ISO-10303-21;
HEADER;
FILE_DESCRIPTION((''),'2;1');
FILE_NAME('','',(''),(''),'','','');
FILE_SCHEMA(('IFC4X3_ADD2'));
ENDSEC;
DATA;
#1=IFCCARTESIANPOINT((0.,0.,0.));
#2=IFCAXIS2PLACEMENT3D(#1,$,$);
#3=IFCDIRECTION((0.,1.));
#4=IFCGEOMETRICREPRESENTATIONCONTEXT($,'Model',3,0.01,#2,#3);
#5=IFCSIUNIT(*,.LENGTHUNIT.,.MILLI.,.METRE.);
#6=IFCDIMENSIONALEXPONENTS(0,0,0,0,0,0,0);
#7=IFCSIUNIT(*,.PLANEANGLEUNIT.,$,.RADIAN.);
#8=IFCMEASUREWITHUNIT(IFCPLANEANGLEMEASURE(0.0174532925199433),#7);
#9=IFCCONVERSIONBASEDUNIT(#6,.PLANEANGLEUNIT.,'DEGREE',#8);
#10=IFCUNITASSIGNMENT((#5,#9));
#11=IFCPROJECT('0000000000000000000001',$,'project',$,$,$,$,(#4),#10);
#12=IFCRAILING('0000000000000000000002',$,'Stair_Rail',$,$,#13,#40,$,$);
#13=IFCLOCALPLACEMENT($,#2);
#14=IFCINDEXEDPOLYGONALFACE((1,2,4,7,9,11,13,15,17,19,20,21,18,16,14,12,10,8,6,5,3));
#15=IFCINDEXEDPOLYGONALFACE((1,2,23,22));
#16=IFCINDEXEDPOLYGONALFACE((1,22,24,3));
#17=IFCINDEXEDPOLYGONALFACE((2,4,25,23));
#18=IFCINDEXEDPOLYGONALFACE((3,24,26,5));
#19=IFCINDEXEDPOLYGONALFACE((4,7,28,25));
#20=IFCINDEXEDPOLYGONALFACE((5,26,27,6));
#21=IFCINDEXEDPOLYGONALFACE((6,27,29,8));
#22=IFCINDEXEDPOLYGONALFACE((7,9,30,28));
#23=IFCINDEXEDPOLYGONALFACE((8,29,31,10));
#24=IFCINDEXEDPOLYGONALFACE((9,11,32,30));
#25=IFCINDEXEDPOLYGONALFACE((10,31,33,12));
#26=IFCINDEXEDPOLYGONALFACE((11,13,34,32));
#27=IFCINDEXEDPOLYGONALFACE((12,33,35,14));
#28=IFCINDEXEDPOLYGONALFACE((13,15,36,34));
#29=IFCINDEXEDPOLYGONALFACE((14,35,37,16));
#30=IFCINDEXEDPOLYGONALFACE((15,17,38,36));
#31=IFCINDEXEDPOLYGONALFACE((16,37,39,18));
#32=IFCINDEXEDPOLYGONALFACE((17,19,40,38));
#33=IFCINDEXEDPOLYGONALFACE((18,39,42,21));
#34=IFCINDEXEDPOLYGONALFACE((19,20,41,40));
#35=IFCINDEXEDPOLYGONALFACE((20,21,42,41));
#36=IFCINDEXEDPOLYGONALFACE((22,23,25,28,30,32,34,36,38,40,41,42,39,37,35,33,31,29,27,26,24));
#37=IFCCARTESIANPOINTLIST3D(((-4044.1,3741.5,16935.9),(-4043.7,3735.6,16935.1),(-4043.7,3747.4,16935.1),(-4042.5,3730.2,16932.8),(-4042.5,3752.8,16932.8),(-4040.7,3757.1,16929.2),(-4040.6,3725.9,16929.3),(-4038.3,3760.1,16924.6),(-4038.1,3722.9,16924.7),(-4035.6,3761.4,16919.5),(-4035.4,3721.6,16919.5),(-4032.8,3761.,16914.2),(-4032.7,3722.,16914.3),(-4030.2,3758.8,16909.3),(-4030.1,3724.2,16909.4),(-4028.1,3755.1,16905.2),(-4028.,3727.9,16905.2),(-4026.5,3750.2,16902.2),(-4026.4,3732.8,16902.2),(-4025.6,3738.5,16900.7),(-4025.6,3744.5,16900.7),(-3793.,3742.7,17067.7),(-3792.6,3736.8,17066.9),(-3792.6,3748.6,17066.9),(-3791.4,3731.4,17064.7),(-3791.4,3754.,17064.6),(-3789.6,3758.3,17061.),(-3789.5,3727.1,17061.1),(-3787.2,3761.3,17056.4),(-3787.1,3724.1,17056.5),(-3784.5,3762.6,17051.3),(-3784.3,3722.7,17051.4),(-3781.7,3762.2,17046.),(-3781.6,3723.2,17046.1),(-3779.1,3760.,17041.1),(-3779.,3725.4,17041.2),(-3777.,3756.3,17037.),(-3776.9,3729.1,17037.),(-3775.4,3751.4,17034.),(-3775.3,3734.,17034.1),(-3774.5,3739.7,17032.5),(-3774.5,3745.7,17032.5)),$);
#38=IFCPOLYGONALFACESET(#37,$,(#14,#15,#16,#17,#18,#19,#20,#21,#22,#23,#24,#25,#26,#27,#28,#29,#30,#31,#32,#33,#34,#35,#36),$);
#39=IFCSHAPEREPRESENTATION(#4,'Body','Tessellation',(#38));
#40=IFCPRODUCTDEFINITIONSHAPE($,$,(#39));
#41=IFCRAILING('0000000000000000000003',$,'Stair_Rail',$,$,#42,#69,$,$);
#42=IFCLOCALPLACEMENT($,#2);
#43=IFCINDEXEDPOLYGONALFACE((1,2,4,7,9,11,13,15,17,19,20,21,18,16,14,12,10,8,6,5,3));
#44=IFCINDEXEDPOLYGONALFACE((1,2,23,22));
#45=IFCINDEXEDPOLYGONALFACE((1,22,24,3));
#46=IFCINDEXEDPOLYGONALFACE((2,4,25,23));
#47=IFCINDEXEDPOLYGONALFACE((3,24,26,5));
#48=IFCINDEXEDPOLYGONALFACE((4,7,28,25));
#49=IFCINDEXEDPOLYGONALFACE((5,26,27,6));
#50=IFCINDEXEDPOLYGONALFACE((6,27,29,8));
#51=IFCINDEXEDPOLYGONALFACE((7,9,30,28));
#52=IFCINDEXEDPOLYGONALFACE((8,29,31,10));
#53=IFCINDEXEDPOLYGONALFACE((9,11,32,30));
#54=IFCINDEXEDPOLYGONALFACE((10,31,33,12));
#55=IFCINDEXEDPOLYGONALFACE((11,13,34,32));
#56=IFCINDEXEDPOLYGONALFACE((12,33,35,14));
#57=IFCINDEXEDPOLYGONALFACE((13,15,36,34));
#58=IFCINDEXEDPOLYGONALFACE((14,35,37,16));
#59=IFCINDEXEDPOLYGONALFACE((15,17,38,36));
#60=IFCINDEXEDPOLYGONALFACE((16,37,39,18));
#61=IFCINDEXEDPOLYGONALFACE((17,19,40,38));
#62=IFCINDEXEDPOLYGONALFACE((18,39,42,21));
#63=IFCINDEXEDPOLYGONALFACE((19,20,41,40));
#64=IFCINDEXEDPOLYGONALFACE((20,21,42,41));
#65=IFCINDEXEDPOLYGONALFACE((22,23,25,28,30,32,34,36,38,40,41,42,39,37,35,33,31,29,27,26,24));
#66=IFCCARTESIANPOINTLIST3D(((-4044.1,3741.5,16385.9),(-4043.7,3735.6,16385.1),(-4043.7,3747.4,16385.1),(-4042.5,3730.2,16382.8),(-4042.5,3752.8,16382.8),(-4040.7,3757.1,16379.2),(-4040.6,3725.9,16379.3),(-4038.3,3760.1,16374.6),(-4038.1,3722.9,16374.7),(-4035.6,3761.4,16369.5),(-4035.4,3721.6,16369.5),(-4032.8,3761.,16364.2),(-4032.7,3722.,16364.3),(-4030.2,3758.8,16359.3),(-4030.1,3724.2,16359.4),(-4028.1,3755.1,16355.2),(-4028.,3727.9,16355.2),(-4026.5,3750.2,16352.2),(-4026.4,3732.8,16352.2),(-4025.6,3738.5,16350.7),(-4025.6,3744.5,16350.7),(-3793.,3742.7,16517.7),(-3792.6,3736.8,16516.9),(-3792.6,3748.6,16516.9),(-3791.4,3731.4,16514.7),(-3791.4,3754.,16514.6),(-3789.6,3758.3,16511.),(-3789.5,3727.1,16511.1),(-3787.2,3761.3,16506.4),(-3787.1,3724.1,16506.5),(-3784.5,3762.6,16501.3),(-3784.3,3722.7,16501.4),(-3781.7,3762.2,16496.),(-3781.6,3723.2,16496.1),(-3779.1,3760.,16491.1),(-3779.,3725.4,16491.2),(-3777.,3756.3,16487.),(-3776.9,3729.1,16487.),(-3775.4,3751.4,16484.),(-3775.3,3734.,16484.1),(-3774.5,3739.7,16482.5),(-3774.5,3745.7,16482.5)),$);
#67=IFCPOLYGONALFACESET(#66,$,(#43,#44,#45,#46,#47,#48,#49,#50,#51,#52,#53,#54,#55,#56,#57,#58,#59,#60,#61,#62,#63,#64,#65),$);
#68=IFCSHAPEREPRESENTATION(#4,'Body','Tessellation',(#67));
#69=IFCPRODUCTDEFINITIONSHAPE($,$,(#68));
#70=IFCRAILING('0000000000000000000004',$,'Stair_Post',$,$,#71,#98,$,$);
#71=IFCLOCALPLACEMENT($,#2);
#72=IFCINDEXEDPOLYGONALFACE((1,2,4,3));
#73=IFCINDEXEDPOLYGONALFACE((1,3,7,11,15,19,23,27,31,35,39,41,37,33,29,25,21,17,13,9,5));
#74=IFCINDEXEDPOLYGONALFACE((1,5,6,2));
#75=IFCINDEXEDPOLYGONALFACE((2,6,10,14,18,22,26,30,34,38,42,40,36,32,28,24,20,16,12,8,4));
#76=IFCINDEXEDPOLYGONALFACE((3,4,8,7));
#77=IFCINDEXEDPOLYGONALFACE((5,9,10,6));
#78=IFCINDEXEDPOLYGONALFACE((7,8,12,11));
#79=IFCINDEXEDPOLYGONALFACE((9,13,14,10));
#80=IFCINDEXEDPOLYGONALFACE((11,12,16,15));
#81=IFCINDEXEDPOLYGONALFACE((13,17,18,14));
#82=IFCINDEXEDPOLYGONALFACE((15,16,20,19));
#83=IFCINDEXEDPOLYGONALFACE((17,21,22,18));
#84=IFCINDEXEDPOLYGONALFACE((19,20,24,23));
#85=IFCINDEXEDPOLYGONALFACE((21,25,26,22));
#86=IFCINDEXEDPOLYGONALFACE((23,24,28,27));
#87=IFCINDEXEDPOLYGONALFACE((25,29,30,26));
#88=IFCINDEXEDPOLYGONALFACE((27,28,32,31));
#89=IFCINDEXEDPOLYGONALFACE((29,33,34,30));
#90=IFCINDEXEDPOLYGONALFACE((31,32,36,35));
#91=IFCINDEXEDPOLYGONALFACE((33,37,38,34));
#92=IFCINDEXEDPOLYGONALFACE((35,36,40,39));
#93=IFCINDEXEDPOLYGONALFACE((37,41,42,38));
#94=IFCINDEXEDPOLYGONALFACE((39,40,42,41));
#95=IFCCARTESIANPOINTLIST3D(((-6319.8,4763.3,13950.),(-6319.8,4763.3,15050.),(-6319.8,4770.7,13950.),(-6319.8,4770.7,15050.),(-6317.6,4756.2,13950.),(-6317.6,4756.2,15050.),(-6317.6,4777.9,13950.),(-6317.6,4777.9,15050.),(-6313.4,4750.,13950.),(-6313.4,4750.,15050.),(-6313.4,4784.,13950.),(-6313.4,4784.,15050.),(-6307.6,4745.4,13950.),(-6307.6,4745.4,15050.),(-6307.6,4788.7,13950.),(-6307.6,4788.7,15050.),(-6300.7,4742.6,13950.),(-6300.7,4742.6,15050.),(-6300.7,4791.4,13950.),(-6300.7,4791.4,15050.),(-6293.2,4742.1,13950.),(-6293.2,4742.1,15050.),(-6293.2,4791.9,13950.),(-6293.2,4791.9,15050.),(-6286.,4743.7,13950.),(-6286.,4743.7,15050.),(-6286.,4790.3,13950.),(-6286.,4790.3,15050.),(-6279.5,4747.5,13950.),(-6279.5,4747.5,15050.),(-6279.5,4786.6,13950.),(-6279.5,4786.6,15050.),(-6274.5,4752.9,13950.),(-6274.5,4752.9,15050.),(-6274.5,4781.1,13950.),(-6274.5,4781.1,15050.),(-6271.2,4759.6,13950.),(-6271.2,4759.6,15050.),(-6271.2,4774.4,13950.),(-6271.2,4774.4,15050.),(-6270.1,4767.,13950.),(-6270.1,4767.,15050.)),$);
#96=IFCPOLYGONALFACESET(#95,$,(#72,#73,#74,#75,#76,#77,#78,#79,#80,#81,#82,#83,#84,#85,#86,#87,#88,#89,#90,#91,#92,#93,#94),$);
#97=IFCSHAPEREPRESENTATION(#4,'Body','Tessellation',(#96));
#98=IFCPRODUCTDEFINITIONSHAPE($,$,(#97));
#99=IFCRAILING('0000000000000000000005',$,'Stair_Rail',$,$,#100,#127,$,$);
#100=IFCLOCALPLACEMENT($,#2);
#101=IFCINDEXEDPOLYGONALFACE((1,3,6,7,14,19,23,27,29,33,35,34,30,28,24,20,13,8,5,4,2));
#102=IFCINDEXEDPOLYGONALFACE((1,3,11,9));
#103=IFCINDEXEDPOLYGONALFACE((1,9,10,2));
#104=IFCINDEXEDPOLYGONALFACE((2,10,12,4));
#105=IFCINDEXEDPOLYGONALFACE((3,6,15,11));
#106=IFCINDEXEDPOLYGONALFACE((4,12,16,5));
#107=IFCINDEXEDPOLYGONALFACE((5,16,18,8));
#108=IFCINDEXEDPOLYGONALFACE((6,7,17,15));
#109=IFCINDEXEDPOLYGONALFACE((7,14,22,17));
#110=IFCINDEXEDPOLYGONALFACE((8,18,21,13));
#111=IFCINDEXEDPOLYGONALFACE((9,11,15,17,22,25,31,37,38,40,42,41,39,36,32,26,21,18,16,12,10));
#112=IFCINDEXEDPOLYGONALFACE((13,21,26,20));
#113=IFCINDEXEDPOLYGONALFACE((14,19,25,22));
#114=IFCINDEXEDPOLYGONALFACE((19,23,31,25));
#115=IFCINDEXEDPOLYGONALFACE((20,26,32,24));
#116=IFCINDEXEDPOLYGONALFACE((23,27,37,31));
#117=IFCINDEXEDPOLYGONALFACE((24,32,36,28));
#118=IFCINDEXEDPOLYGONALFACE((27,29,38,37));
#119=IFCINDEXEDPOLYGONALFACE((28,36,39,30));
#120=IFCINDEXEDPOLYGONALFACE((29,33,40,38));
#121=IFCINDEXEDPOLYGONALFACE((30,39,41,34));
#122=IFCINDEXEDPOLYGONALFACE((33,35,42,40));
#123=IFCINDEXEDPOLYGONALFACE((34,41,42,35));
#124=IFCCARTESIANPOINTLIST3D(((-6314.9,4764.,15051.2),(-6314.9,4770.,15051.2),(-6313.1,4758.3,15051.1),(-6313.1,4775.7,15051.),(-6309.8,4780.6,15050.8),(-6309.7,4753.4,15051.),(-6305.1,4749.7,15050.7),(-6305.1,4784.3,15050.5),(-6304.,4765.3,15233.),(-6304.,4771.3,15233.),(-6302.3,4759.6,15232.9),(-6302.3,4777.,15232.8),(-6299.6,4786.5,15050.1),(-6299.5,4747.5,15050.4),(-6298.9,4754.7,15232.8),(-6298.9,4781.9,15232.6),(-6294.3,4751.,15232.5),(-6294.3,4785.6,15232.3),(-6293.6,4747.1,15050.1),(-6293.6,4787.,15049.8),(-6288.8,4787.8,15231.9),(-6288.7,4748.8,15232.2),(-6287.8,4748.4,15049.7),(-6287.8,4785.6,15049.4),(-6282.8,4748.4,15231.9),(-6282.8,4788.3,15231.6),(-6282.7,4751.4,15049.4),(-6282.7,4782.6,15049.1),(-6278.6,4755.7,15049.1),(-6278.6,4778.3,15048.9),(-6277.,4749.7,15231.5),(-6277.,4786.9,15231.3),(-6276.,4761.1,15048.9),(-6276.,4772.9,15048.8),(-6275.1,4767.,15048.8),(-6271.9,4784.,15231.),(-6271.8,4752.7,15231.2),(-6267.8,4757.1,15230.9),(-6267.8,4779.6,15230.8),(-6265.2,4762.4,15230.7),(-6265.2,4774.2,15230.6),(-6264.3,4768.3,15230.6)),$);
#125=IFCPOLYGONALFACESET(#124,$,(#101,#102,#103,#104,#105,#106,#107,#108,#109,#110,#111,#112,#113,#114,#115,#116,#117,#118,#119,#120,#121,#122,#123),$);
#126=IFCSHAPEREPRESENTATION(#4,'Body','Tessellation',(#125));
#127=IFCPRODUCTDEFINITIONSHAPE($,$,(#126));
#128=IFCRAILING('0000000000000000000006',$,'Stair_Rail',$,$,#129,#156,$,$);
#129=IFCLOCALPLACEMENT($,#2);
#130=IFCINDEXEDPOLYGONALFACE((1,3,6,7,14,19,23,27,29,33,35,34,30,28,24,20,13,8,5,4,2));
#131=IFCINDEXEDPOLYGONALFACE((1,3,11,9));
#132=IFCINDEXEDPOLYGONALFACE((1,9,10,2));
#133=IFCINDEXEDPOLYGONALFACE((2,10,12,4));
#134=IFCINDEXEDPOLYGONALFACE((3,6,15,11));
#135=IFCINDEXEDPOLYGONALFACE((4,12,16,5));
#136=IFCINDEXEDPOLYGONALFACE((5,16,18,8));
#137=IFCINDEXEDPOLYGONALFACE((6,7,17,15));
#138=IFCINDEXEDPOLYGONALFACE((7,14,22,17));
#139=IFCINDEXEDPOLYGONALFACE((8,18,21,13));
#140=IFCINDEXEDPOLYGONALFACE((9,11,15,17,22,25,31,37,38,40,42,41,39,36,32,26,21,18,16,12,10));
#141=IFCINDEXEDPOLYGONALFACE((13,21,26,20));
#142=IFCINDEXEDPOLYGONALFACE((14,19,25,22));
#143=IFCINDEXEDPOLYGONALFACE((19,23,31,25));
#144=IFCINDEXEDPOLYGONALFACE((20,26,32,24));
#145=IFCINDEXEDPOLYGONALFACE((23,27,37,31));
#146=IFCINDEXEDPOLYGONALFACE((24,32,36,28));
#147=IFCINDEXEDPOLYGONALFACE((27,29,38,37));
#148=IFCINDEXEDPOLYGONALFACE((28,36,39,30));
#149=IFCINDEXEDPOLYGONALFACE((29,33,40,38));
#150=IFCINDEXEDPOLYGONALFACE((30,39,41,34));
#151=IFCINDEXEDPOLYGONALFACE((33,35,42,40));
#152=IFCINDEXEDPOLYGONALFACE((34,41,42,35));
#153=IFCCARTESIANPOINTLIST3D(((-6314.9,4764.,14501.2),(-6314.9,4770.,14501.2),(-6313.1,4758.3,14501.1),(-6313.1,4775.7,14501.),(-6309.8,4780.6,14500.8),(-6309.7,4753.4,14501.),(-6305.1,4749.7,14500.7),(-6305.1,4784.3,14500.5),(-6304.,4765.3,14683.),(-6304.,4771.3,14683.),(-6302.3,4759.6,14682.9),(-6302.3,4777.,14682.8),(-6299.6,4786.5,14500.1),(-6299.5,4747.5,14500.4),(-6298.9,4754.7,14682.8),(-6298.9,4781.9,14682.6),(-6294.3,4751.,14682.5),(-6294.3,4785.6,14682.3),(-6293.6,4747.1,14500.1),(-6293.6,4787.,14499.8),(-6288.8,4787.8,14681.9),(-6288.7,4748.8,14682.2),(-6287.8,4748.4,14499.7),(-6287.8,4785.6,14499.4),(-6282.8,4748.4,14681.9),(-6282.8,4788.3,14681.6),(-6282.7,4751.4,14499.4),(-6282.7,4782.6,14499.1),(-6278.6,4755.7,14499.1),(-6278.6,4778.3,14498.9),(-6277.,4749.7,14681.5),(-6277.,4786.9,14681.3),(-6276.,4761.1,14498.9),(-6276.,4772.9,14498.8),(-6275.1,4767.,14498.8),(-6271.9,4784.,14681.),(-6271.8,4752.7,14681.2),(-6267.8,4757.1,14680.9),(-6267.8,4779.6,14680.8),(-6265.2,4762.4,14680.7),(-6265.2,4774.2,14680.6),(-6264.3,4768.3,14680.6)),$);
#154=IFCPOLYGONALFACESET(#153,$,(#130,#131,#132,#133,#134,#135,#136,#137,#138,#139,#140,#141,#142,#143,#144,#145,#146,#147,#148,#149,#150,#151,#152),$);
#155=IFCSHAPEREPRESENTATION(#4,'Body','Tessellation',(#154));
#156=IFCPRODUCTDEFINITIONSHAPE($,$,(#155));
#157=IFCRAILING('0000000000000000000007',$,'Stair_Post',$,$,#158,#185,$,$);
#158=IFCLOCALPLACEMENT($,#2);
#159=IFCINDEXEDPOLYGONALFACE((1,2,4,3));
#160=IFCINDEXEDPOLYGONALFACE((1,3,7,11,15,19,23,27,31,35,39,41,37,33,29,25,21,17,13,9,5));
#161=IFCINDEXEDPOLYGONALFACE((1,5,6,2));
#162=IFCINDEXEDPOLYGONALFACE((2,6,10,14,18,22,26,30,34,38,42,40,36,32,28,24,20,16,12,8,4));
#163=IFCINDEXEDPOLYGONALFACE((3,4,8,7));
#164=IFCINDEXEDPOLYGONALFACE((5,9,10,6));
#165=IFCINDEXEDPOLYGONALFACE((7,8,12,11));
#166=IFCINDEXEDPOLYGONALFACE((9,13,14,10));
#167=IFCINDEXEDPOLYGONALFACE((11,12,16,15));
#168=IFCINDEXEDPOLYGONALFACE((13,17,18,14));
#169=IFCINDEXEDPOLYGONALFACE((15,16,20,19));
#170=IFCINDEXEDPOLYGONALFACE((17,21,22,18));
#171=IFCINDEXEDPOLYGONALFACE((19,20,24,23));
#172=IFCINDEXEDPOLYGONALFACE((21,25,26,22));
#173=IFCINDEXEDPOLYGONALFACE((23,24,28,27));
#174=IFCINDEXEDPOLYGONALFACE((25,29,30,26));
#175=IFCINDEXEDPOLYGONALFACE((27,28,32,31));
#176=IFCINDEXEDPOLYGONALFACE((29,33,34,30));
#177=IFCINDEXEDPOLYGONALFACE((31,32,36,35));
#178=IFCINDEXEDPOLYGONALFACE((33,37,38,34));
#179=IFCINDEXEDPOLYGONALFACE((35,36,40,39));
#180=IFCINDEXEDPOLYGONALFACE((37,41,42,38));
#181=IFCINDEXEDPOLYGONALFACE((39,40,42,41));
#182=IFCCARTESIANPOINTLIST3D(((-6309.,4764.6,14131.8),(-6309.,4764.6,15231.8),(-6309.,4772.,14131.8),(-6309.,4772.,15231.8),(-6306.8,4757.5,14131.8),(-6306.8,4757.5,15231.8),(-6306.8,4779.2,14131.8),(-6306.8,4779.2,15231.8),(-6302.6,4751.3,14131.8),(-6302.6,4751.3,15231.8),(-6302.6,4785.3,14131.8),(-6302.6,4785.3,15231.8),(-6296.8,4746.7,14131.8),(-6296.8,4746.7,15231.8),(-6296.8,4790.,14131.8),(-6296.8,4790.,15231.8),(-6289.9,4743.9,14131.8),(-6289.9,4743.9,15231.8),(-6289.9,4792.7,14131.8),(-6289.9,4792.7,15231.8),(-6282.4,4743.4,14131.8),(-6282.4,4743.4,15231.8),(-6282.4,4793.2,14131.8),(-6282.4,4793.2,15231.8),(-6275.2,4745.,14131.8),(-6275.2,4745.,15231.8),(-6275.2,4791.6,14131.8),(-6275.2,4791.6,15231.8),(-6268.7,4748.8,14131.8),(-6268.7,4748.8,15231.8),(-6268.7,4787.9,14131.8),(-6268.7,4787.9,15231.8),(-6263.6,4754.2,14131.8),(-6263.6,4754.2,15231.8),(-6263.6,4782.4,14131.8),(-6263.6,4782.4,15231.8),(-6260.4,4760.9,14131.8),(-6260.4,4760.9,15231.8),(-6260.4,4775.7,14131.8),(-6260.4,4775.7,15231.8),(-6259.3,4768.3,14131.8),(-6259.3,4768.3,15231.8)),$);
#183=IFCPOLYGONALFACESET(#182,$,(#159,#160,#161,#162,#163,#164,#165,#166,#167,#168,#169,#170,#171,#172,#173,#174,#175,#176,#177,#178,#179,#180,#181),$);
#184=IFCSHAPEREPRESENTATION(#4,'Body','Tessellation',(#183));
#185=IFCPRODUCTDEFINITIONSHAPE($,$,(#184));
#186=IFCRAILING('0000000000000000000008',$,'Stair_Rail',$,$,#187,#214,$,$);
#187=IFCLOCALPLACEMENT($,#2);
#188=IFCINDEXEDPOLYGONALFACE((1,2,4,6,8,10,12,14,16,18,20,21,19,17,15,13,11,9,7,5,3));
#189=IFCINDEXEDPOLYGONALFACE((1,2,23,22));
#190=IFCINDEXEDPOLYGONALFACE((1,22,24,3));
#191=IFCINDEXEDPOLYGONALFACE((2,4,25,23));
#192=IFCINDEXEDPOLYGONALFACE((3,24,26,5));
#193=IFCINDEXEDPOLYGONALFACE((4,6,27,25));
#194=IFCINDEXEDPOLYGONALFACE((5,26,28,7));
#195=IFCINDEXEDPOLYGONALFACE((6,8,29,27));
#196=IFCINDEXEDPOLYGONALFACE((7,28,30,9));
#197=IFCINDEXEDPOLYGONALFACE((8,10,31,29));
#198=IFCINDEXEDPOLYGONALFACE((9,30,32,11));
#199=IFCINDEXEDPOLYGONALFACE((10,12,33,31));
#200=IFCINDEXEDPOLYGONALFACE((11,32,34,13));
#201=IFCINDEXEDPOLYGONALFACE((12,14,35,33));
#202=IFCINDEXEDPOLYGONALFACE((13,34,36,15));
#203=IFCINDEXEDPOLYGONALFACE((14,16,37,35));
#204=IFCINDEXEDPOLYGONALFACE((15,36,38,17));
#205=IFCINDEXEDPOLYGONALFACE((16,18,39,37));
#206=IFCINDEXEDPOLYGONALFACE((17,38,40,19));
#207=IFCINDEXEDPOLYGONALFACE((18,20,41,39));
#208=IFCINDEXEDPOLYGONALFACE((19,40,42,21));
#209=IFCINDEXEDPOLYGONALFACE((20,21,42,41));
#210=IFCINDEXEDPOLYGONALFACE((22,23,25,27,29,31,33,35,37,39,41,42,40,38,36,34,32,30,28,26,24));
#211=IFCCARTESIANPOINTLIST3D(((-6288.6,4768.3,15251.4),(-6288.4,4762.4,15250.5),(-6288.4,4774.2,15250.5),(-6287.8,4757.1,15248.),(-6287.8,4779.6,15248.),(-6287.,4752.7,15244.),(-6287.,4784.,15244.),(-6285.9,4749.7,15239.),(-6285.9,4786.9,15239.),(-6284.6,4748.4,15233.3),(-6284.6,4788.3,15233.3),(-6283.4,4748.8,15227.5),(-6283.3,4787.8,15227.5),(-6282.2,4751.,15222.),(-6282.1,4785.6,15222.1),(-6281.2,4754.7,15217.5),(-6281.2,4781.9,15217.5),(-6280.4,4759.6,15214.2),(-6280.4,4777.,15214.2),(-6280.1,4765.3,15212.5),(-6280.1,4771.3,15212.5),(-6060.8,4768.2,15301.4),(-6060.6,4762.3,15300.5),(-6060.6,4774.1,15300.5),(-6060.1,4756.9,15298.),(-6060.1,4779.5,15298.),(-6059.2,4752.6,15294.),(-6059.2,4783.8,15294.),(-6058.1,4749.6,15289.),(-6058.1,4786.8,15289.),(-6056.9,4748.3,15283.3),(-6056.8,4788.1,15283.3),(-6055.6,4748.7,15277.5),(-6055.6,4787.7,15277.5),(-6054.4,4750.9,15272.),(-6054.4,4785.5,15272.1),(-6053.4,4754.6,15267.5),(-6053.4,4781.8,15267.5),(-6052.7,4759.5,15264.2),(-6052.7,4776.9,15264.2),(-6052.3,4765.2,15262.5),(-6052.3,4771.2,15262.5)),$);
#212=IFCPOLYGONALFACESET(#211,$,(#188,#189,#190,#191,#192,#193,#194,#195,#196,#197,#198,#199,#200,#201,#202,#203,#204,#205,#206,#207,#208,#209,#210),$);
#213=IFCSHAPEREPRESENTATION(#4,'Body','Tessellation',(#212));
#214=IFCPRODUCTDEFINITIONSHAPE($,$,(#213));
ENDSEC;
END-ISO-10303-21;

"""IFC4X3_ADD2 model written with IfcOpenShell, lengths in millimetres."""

from ifc_helpers import new_model, entity, si_unit, converted_unit, direction, frame, origin, context, project, circle, extrude, element, save


model = new_model("IFC4X3_ADD2")

# Units and contexts
model_context = context("Model", 3, precision=0.01, world=origin(), true_north=direction((0.0, 1.0)))
ifc_project = project(units=[si_unit("LENGTHUNIT", "METRE", prefix="MILLI"), converted_unit("PLANEANGLEUNIT", "DEGREE", entity("IfcPlaneAngleMeasure", 0.0174532925199433), si_unit("PLANEANGLEUNIT", "RADIAN"), dimensions=[0, 0, 0, 0, 0, 0, 0])], contexts=[model_context])

# Railings
element("IfcRailing", 1, Name="Stair_Rail", context=model_context, shape_type="SweptSolid", body=[
    entity("IfcSweptDiskSolid", entity("IfcPolyline", [entity("IfcCartesianPoint", [-4034.8, 3741.5, 16918.2]), entity("IfcCartesianPoint", [-3783.7, 3742.7, 17050.0])]), 20.0),
])
element("IfcRailing", 2, Name="Stair_Rail", context=model_context, shape_type="SweptSolid", body=[
    entity("IfcSweptDiskSolid", entity("IfcPolyline", [entity("IfcCartesianPoint", [-4034.8, 3741.5, 16368.2]), entity("IfcCartesianPoint", [-3783.7, 3742.7, 16500.0])]), 20.0),
])
element("IfcRailing", 3, Name="Stair_Post", context=model_context, shape_type="SweptSolid", body=[
    extrude(circle(Radius=25.0), frame((-6295.1, 4767.0, 13950.0)), (0.0, 0.0, 1.0), 1100.0),
])
element("IfcRailing", 4, Name="Stair_Rail", context=model_context, shape_type="SweptSolid", body=[
    entity("IfcSweptDiskSolid", entity("IfcPolyline", [entity("IfcCartesianPoint", [-6295.1, 4767.0, 15050.0]), entity("IfcCartesianPoint", [-6284.3, 4768.3, 15231.8])]), 20.0),
])
element("IfcRailing", 5, Name="Stair_Rail", context=model_context, shape_type="SweptSolid", body=[
    entity("IfcSweptDiskSolid", entity("IfcPolyline", [entity("IfcCartesianPoint", [-6295.1, 4767.0, 14500.0]), entity("IfcCartesianPoint", [-6284.3, 4768.3, 14681.8])]), 20.0),
])
element("IfcRailing", 6, Name="Stair_Post", context=model_context, shape_type="SweptSolid", body=[
    extrude(circle(Radius=25.0), frame((-6284.3, 4768.3, 14131.8)), (0.0, 0.0, 1.0), 1100.0),
])
element("IfcRailing", 7, Name="Stair_Rail", context=model_context, shape_type="SweptSolid", body=[
    entity("IfcSweptDiskSolid", entity("IfcPolyline", [entity("IfcCartesianPoint", [-6284.3, 4768.3, 15231.8]), entity("IfcCartesianPoint", [-6056.5, 4768.2, 15281.8])]), 20.0),
])

save(model, "model.ifc")
